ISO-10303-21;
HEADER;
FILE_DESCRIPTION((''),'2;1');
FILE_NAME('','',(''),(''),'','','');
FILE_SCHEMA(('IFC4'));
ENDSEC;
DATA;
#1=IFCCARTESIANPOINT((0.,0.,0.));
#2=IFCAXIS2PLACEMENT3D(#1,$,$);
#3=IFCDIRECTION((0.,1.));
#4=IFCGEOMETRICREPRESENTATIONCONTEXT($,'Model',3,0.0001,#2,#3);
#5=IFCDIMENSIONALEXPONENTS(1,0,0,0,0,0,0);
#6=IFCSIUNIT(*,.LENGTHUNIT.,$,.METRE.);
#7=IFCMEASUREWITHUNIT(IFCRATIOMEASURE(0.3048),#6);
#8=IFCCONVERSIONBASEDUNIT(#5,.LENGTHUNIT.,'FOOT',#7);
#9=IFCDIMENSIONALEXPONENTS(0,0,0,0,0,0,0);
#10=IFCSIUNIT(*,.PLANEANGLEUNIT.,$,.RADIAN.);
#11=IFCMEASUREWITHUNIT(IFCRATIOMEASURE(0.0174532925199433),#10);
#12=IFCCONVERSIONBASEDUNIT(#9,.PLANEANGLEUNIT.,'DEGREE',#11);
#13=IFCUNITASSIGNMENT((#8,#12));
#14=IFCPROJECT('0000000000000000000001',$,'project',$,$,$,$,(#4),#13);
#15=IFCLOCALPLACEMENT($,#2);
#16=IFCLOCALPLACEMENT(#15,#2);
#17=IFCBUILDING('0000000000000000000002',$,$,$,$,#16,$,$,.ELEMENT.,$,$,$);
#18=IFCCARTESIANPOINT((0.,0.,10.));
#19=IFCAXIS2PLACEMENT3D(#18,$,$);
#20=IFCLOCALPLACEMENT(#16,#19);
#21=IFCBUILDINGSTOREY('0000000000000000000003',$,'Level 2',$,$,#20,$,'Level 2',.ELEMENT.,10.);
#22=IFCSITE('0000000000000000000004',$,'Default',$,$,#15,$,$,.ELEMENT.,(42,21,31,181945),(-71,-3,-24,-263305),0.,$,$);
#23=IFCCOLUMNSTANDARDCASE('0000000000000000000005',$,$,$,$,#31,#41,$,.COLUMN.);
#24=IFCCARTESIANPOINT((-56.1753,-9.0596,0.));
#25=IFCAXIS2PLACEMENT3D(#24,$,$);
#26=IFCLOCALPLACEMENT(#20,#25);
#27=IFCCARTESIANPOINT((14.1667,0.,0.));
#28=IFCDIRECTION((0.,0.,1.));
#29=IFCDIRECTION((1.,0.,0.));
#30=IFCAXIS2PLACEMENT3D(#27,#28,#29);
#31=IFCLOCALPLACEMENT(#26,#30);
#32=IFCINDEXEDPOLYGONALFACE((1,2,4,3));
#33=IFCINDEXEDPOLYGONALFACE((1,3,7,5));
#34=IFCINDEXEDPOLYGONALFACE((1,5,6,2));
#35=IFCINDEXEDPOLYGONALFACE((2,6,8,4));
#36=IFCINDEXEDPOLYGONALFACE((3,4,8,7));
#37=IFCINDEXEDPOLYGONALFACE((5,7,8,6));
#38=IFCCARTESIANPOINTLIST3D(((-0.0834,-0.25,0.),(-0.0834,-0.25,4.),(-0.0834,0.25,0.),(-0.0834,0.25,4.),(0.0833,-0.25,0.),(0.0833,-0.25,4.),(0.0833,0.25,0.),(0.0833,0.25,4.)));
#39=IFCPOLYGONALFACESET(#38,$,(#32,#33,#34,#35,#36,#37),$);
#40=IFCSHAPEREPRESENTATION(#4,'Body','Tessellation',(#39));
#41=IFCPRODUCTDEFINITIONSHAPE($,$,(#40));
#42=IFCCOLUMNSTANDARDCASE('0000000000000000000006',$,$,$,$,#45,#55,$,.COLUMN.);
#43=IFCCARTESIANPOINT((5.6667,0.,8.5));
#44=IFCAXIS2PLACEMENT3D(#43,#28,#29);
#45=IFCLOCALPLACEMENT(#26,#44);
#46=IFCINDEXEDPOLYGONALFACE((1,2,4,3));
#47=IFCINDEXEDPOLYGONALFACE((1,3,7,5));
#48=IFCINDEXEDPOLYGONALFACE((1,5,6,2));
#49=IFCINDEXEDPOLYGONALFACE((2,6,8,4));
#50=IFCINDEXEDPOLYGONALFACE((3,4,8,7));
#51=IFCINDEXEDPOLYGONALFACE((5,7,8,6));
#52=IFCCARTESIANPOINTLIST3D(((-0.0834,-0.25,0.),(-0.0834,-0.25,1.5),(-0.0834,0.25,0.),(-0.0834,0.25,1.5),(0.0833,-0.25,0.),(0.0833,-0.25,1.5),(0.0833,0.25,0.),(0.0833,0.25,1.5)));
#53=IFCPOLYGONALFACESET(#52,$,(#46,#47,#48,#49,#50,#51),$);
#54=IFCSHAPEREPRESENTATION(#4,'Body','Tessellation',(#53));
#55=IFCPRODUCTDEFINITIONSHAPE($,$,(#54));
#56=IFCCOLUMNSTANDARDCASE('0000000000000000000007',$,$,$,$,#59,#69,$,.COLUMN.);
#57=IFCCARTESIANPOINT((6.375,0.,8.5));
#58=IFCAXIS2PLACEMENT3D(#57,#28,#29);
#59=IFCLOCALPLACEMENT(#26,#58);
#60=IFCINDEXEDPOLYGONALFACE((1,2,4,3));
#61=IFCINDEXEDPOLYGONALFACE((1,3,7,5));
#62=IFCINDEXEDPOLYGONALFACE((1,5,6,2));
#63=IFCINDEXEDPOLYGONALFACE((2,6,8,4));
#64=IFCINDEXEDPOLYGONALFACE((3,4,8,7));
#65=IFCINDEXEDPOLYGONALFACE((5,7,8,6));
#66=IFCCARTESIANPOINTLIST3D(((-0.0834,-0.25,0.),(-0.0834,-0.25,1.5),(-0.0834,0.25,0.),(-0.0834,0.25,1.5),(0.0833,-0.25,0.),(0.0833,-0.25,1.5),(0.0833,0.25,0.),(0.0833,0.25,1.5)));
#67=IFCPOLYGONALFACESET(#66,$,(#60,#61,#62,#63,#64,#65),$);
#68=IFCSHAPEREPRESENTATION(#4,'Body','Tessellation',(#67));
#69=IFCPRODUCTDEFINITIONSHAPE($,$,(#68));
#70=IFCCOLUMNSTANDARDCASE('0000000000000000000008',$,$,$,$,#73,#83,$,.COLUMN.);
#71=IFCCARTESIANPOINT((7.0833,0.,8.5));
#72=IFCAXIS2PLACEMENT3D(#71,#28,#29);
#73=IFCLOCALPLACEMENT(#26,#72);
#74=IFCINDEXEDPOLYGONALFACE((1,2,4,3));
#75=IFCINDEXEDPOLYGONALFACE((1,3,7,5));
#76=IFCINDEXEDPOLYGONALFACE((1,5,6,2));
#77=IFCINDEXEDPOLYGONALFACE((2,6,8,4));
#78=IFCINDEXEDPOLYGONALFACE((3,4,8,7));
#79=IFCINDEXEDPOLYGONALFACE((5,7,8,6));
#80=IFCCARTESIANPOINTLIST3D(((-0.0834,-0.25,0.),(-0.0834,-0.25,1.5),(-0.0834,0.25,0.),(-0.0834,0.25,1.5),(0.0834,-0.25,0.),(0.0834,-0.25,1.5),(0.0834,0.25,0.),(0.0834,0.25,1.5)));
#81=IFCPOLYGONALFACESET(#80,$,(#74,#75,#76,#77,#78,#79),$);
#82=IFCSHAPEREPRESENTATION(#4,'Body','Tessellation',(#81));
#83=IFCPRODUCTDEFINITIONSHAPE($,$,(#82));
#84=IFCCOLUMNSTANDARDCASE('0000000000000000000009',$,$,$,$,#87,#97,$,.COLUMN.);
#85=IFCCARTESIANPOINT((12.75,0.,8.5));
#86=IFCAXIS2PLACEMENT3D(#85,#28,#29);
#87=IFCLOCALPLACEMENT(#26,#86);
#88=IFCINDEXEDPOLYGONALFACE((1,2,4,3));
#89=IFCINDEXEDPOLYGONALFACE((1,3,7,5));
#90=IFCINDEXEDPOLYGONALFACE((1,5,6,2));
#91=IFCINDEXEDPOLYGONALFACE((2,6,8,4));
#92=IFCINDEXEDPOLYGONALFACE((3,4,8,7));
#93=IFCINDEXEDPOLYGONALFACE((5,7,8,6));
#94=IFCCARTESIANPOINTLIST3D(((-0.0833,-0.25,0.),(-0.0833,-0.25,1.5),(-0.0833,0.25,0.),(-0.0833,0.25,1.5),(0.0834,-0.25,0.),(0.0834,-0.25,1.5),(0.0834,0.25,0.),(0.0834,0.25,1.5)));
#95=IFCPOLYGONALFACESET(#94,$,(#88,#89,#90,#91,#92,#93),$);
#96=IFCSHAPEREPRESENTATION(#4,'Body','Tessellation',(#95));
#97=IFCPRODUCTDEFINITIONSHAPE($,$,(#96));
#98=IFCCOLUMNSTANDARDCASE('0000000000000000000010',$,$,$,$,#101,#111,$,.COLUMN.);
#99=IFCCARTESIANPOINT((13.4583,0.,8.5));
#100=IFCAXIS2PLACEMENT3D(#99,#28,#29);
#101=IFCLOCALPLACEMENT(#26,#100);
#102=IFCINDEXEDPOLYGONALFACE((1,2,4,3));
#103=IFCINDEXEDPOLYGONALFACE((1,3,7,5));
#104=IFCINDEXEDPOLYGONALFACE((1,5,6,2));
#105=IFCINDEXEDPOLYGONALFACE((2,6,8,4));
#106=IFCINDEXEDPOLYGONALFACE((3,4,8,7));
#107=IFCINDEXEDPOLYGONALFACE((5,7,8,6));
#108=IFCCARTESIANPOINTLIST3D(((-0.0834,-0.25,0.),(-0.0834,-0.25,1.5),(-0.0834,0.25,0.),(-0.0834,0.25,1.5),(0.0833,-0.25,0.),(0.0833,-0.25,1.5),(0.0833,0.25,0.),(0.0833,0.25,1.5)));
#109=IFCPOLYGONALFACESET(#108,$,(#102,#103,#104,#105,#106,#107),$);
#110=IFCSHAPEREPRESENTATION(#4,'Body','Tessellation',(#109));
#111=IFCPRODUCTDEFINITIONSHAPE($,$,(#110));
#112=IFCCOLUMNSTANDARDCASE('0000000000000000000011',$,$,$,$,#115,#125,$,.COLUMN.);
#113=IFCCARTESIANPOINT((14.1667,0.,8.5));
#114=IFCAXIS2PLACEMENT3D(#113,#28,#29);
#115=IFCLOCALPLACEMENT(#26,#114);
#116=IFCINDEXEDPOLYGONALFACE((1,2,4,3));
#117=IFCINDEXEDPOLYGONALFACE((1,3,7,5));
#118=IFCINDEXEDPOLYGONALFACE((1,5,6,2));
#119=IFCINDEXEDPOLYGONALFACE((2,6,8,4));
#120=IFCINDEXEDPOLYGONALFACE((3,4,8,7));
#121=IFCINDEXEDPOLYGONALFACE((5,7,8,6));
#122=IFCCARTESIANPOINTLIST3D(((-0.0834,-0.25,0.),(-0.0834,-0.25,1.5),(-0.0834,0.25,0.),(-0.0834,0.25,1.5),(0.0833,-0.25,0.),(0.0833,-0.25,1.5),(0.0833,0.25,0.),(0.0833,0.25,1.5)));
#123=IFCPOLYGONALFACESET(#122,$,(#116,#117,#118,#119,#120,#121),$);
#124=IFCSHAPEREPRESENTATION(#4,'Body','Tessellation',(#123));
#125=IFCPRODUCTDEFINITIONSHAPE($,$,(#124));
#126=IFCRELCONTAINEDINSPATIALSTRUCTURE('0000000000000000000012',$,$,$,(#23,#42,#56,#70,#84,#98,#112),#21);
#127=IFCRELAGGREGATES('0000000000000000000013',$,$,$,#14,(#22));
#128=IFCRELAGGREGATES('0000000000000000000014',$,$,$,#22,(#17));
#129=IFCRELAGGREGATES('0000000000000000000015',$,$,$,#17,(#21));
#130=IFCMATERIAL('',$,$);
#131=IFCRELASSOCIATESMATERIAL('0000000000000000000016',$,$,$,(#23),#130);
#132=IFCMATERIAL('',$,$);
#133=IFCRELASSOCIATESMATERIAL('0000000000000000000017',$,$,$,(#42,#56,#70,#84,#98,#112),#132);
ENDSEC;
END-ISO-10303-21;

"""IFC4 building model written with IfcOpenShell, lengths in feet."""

from ifc_helpers import new_model, entity, si_unit, converted_unit, direction, frame, origin, place, context, project, spatial, rectangle, extrude, material, element, save


model = new_model("IFC4")

# Units and contexts
model_context = context("Model", 3, precision=0.0001, world=origin(), true_north=direction((0.0, 1.0)))
ifc_project = project(units=[converted_unit("LENGTHUNIT", "FOOT", entity("IfcRatioMeasure", 0.3048), si_unit("LENGTHUNIT", "METRE"), dimensions=[1, 0, 0, 0, 0, 0, 0]), converted_unit("PLANEANGLEUNIT", "DEGREE", entity("IfcRatioMeasure", 0.0174532925199433), si_unit("PLANEANGLEUNIT", "RADIAN"), dimensions=[0, 0, 0, 0, 0, 0, 0])], contexts=[model_context])

# Site, building, storey
site_placement = place(None, origin())
site = spatial("IfcSite", under=ifc_project, at=site_placement, Name="Default", CompositionType="ELEMENT", RefLatitude=(42, 21, 31, 181945), RefLongitude=(-71, -3, -24, -263305), RefElevation=0.0)
building_placement = place(site_placement, origin())
building = spatial("IfcBuilding", under=site, at=building_placement, CompositionType="ELEMENT")
storey_placement = place(building_placement, frame((0.0, 0.0, 10.0)))
storey = spatial("IfcBuildingStorey", under=building, at=storey_placement, Name="Level 2", LongName="Level 2", CompositionType="ELEMENT", Elevation=10.0)

# Columns
ifc_material_1 = material(Name="")
placement = place(storey_placement, frame((-56.1753, -9.0596, 0.0)))
for number, where, z_axis, x_axis in (
    (1, (14.1667, 0.0, 0.0), (0.0, 0.0, 1.0), (1.0, 0.0, 0.0)),
):
    element("IfcColumnStandardCase", number, at=place(placement, frame(where, z_axis=z_axis, x_axis=x_axis)), inside=storey, material=ifc_material_1, PredefinedType="COLUMN", context=model_context, shape_type="SweptSolid", body=[
        extrude(rectangle(XDim=0.1667, YDim=0.5), origin(), (0.0, 0.0, 1.0), 4.0),
    ])
ifc_material_2 = material(Name="")
for number, where, z_axis, x_axis in (
    (2, (5.6667, 0.0, 8.5), (0.0, 0.0, 1.0), (1.0, 0.0, 0.0)),
    (3, (6.375, 0.0, 8.5), (0.0, 0.0, 1.0), (1.0, 0.0, 0.0)),
    (4, (7.0833, 0.0, 8.5), (0.0, 0.0, 1.0), (1.0, 0.0, 0.0)),
    (5, (12.75, 0.0, 8.5), (0.0, 0.0, 1.0), (1.0, 0.0, 0.0)),
    (6, (13.4583, 0.0, 8.5), (0.0, 0.0, 1.0), (1.0, 0.0, 0.0)),
    (7, (14.1667, 0.0, 8.5), (0.0, 0.0, 1.0), (1.0, 0.0, 0.0)),
):
    element("IfcColumnStandardCase", number, at=place(placement, frame(where, z_axis=z_axis, x_axis=x_axis)), inside=storey, material=ifc_material_2, PredefinedType="COLUMN", context=model_context, shape_type="SweptSolid", body=[
        extrude(rectangle(XDim=0.1667, YDim=0.5), origin(), (0.0, 0.0, 1.0), 1.5),
    ])

save(model, "model.ifc")
